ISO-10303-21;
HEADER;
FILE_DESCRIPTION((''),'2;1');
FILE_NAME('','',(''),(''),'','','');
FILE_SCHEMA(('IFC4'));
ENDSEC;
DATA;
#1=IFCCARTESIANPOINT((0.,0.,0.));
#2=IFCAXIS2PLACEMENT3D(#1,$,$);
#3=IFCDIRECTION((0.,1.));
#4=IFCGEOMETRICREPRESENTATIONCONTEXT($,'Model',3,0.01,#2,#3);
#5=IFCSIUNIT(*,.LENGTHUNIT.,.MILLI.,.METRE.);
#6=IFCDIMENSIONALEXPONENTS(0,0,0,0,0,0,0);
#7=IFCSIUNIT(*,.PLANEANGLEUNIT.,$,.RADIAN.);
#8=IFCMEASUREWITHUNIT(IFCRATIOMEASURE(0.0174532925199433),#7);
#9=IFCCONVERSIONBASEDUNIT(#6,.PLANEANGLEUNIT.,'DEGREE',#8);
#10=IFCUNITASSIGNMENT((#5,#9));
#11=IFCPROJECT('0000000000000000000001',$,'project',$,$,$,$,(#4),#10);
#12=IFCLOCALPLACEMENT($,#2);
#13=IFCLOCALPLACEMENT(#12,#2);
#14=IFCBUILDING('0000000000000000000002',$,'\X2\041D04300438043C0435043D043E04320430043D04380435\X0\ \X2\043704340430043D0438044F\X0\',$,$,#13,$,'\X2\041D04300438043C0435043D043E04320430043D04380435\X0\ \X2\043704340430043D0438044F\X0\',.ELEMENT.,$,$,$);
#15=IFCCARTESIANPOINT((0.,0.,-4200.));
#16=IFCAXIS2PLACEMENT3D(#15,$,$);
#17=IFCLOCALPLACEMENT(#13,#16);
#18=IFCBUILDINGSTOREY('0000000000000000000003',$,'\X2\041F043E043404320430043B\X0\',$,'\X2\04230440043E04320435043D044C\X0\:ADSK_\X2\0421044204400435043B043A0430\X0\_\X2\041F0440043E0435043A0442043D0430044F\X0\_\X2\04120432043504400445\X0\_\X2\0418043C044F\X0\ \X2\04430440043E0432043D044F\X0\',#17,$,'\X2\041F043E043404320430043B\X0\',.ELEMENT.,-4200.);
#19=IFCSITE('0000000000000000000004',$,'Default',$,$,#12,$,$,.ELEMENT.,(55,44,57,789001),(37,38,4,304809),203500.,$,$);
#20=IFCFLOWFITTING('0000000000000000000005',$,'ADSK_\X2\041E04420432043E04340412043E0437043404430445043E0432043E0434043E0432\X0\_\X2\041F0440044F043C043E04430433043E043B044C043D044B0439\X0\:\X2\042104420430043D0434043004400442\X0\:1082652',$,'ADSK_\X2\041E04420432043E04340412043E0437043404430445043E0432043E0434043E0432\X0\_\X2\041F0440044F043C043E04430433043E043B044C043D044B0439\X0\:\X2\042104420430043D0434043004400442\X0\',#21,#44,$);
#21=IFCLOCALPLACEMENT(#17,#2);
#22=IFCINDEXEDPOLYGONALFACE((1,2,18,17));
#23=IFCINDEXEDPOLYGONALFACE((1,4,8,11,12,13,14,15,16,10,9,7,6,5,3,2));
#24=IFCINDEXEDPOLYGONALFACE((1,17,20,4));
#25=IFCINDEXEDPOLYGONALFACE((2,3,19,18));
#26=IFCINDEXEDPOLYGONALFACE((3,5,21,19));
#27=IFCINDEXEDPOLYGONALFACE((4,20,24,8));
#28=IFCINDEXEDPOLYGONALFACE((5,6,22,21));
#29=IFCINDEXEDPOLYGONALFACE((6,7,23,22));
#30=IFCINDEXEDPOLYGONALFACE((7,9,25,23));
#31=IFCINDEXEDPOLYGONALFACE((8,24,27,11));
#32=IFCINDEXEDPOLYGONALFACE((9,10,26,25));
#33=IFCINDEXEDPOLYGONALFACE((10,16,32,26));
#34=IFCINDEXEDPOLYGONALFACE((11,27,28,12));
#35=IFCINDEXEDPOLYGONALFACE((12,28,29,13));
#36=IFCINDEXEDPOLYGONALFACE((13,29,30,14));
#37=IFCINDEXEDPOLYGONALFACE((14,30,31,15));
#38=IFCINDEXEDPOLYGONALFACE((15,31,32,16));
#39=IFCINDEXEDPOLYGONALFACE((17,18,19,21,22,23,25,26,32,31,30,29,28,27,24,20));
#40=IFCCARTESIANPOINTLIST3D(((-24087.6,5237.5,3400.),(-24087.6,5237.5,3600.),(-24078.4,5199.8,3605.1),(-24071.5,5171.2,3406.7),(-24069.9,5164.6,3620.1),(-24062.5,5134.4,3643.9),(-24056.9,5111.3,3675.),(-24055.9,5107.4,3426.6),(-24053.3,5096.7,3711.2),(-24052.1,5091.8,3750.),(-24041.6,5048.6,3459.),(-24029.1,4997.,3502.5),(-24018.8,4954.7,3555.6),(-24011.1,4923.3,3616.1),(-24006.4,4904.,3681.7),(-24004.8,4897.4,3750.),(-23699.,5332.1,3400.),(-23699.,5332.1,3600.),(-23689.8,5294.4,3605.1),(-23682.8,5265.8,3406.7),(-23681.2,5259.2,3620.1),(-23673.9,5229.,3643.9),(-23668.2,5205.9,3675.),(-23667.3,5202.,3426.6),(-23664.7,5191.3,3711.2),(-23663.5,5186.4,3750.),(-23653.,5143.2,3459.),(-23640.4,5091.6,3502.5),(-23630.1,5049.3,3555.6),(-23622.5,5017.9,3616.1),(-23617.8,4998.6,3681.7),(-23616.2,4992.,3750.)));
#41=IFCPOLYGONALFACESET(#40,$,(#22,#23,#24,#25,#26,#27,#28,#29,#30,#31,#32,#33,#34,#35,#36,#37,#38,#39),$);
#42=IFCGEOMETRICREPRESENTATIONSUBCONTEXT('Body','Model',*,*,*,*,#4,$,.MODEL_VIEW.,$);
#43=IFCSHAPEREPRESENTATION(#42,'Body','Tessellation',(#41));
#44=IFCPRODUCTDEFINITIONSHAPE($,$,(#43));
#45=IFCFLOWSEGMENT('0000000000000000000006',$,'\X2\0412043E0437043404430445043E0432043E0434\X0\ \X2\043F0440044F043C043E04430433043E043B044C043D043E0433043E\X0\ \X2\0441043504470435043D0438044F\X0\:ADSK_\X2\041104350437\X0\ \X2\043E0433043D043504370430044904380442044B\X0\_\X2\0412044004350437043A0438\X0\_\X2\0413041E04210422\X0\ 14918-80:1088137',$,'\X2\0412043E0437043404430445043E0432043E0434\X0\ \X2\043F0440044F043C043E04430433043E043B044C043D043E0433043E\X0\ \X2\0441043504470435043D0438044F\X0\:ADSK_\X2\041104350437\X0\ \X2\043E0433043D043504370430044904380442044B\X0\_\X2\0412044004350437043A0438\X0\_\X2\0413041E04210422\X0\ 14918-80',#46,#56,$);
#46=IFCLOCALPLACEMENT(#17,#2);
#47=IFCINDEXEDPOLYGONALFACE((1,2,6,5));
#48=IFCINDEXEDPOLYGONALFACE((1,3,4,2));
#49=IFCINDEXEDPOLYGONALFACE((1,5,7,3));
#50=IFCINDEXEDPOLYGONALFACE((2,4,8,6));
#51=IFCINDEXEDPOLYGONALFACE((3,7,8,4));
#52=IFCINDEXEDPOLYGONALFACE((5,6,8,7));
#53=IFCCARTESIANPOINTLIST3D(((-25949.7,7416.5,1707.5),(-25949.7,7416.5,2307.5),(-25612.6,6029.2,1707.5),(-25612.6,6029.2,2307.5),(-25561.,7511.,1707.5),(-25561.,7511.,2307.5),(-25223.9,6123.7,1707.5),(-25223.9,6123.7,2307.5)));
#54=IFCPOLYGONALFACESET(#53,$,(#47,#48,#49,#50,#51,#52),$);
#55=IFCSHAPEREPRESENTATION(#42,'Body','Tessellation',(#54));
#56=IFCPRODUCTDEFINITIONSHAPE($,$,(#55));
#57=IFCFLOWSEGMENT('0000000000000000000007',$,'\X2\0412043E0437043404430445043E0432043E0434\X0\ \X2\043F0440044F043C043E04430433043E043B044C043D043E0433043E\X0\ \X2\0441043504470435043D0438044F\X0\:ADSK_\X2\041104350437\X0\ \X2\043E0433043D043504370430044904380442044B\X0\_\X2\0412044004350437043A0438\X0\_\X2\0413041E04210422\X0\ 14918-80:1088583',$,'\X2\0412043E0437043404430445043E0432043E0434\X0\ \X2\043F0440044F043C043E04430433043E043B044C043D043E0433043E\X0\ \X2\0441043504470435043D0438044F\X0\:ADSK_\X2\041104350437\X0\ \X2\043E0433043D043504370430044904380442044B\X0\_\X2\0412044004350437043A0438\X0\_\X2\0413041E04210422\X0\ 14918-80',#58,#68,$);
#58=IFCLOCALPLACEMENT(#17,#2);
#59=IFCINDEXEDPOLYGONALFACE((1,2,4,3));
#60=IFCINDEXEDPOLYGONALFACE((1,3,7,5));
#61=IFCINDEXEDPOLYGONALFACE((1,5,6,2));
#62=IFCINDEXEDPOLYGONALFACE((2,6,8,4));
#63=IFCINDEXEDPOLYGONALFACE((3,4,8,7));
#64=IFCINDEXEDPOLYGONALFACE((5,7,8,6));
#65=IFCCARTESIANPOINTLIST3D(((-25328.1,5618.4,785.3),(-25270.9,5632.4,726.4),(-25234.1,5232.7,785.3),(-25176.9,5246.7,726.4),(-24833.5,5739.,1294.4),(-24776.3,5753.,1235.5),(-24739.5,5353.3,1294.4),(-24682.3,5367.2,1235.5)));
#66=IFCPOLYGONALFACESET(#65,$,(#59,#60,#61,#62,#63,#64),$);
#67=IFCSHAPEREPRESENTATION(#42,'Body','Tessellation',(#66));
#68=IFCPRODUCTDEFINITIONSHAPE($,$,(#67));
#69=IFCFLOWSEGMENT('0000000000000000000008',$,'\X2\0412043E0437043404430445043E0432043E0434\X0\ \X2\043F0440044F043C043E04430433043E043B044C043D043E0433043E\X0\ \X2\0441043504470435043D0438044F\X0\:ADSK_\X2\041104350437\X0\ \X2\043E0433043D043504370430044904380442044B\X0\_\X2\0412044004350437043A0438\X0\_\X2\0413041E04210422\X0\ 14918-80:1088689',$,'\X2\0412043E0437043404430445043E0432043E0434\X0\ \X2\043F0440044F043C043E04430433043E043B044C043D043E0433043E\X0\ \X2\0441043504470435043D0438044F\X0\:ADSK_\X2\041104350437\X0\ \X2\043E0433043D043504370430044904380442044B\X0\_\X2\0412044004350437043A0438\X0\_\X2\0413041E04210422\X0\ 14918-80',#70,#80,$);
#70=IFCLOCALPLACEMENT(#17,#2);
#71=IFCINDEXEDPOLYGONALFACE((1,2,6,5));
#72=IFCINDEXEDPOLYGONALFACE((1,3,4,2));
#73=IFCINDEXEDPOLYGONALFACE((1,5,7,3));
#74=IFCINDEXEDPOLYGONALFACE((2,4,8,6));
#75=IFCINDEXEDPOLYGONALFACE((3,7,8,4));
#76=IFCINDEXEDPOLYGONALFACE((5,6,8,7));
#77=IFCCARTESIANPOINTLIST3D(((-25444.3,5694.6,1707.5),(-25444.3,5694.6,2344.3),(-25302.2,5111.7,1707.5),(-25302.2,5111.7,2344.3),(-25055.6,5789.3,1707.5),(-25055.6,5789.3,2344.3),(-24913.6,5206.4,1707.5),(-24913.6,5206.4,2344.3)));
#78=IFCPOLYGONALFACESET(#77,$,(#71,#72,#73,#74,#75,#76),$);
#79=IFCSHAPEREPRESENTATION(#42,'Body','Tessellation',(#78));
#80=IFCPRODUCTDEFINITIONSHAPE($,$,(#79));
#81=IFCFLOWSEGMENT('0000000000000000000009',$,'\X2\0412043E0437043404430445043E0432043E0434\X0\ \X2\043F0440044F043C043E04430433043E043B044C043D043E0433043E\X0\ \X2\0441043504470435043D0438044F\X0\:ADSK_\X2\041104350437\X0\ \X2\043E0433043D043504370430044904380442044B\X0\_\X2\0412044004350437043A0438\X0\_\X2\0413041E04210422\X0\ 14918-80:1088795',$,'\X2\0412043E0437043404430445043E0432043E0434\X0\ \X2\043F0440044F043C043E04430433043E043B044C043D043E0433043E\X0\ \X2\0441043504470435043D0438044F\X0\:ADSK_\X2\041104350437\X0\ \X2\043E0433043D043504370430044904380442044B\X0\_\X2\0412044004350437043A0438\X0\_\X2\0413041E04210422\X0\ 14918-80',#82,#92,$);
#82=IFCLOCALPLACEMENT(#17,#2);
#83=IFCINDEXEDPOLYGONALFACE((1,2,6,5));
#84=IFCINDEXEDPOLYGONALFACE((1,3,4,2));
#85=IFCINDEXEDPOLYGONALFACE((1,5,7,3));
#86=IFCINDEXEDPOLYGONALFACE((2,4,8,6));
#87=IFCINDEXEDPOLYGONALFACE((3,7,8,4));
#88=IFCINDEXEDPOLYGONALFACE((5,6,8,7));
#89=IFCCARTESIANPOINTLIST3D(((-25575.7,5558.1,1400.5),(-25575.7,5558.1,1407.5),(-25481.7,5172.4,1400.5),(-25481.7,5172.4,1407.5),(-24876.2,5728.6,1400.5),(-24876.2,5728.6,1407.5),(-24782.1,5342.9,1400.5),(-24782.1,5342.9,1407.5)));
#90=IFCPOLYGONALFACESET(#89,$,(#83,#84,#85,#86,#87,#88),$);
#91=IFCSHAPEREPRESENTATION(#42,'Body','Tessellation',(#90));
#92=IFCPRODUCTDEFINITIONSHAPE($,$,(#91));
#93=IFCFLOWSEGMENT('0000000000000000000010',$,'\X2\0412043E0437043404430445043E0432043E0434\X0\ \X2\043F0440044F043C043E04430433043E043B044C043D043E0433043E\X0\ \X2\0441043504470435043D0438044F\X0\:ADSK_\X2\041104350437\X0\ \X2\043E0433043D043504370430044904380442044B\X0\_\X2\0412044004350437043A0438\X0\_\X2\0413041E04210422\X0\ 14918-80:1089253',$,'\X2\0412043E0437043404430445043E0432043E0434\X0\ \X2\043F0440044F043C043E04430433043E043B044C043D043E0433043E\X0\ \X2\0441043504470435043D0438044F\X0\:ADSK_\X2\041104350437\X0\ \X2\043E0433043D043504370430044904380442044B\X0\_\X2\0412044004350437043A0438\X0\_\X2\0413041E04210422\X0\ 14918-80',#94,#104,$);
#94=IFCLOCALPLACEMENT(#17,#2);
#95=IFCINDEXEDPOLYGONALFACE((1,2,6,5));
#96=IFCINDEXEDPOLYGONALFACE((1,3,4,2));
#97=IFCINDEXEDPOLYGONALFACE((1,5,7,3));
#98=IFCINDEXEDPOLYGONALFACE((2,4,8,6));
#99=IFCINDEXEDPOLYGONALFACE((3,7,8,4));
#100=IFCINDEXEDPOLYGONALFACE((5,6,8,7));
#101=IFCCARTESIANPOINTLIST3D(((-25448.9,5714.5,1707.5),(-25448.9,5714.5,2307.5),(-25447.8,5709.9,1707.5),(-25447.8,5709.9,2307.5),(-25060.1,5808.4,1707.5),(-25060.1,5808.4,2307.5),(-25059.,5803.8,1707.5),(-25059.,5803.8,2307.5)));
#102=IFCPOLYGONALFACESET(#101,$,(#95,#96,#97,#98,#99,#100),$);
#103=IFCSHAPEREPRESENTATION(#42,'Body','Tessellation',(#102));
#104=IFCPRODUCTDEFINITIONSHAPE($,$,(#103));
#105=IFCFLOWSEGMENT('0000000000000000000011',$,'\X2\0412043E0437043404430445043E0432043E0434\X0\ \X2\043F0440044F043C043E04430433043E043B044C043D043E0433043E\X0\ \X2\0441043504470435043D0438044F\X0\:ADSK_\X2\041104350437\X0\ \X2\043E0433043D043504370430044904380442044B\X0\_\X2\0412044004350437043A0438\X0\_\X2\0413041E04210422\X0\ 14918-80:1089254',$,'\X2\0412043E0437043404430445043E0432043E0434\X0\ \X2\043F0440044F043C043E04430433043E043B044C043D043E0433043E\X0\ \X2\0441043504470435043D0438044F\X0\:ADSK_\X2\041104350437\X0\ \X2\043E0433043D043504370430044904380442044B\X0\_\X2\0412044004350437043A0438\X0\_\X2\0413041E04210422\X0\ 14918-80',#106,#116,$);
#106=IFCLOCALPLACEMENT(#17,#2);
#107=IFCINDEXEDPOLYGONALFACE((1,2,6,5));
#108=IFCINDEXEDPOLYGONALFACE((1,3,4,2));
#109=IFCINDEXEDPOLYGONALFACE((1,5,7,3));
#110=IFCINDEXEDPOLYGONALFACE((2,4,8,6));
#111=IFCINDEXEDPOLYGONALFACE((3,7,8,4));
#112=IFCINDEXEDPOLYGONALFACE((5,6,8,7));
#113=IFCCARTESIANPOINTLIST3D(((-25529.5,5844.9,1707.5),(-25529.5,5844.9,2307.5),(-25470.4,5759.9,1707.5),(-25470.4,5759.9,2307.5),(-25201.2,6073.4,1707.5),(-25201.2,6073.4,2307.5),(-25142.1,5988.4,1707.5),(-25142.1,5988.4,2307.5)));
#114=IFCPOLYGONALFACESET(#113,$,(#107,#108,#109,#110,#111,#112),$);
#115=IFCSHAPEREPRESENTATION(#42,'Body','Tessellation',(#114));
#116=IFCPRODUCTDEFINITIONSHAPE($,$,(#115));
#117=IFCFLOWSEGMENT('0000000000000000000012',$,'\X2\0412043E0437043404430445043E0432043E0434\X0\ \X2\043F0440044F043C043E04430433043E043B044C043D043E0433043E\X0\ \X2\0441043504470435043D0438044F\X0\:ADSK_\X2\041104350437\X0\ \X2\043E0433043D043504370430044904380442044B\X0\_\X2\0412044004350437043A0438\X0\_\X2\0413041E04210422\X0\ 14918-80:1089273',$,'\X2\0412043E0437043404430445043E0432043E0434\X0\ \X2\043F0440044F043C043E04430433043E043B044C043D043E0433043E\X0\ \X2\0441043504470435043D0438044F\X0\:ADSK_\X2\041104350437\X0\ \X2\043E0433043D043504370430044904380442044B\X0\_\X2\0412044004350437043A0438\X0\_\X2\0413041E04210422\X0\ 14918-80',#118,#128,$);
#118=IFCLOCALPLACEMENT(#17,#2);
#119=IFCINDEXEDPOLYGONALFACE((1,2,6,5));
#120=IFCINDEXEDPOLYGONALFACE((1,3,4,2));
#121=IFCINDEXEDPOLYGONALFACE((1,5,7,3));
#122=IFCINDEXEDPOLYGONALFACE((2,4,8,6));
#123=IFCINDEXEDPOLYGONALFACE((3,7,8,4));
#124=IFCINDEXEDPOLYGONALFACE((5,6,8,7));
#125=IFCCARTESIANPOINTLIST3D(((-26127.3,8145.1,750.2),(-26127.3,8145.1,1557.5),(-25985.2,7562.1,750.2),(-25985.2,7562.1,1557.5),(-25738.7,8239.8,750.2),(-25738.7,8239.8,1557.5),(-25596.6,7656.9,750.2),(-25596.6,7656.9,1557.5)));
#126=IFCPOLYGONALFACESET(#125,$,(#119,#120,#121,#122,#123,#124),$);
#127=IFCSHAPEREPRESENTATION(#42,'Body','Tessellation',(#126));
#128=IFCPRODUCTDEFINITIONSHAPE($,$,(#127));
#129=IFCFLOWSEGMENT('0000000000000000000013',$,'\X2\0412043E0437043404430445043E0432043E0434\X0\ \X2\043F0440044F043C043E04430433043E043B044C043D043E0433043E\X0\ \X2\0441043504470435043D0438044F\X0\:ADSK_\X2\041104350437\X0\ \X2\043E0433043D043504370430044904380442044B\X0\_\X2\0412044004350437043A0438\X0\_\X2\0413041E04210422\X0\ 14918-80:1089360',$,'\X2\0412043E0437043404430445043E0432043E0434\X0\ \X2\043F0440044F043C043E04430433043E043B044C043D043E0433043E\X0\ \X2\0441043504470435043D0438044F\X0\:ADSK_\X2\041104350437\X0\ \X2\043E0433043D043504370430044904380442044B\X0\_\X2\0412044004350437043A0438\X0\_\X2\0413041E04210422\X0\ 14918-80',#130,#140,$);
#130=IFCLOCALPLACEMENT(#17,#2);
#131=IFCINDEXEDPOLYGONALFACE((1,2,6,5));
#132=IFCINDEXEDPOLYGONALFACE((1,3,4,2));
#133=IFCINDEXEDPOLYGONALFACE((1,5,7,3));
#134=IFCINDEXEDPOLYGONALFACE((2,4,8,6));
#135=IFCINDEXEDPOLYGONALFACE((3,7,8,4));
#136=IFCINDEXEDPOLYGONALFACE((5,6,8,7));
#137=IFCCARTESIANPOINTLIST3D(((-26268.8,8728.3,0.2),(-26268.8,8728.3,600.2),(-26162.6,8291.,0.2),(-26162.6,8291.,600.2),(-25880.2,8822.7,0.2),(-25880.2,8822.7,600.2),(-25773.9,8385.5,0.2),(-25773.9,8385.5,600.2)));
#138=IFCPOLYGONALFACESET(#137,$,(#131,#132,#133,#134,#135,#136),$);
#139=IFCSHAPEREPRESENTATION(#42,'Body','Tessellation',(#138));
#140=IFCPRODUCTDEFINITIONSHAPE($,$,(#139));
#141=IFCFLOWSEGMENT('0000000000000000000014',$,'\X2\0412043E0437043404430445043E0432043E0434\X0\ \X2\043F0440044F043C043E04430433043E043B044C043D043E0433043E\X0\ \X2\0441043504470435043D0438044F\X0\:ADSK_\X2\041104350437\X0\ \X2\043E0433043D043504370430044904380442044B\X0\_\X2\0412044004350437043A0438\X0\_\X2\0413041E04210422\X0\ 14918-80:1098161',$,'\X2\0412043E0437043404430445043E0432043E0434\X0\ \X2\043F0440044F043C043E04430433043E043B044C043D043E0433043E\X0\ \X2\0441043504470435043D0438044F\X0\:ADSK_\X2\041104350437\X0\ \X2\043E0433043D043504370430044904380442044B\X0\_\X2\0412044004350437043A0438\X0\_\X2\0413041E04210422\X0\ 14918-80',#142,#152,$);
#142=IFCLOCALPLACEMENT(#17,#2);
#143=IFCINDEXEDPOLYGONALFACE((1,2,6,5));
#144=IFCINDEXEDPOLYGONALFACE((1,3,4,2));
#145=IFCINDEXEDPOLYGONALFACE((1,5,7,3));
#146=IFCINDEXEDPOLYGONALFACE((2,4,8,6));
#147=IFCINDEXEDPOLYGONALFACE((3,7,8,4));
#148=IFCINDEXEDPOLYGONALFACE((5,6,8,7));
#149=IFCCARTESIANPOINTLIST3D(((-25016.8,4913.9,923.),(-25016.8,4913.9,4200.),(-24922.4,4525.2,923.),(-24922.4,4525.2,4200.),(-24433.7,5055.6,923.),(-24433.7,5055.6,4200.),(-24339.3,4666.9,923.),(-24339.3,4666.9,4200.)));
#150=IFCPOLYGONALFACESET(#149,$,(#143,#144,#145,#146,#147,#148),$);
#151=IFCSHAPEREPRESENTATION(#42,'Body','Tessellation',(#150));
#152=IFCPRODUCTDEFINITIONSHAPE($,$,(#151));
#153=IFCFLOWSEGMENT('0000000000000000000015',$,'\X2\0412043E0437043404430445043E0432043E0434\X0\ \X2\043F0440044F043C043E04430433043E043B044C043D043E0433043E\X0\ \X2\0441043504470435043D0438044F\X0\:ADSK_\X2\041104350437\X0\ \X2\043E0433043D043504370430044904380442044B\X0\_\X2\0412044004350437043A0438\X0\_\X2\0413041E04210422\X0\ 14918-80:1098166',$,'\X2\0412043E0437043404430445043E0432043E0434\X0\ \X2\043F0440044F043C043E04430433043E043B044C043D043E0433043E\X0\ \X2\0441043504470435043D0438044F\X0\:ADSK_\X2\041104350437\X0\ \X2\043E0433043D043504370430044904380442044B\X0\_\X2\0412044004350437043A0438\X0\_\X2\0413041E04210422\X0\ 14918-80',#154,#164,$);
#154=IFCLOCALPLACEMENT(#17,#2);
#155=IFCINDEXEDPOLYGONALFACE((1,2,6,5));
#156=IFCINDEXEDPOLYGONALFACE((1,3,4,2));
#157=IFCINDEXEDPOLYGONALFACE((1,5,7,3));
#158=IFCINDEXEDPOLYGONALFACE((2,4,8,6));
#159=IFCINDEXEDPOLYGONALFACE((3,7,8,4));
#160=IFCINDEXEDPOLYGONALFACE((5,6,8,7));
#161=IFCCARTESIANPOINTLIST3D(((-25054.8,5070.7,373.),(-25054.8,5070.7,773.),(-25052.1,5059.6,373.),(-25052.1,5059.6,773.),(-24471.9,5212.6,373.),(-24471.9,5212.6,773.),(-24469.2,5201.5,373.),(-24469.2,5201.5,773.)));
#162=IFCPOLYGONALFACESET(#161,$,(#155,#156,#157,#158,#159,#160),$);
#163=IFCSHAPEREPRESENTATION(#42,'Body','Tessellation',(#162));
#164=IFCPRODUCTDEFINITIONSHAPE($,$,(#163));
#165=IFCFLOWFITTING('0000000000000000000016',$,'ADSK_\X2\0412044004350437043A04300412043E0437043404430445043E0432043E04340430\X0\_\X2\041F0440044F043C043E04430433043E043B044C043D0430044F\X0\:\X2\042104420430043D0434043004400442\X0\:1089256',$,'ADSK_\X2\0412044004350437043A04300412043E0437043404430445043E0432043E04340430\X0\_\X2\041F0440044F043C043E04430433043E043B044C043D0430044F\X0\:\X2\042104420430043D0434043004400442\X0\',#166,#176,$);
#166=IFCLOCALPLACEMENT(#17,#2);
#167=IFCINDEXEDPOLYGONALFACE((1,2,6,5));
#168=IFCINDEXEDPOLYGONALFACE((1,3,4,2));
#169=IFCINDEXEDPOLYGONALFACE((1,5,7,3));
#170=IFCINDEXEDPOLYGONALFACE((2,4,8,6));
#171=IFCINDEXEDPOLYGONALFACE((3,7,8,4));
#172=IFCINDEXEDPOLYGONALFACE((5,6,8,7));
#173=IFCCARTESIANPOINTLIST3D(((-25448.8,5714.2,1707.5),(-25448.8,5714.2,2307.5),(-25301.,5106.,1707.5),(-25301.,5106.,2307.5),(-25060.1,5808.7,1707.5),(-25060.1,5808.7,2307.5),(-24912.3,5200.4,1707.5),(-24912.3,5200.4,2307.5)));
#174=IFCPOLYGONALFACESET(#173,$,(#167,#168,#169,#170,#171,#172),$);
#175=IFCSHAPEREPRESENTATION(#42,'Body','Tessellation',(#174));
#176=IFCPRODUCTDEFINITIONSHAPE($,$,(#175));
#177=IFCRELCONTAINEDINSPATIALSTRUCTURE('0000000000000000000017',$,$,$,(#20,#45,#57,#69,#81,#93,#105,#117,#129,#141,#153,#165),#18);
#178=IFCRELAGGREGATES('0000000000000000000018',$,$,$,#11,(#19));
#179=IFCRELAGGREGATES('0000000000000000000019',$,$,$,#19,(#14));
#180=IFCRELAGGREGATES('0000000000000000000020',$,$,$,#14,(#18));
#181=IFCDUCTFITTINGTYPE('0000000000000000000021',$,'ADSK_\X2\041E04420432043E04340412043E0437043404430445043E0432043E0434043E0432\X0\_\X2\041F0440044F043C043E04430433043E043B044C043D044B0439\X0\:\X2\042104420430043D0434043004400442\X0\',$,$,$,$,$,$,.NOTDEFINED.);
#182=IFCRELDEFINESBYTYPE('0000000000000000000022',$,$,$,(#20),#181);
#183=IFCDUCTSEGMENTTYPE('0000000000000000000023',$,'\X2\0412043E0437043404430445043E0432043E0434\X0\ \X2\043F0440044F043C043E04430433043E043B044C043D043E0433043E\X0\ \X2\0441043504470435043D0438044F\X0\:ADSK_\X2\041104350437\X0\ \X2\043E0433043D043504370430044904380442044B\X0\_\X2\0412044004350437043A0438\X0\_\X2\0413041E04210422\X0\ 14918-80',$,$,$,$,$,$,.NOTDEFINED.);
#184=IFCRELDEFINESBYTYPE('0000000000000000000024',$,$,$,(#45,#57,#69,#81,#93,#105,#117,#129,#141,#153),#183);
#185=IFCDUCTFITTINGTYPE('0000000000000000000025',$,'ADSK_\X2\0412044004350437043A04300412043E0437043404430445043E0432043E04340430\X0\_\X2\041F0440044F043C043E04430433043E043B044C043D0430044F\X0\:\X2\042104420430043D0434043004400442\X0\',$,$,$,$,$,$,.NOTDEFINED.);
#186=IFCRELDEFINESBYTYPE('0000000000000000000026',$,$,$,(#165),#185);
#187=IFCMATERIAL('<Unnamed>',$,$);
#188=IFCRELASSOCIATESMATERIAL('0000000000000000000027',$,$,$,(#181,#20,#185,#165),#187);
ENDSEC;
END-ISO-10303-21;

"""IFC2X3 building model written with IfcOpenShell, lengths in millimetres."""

from ifc_helpers import new_model, entity, si_unit, converted_unit, direction, frame, frame_2d, origin, origin_2d_with_axis, place, context, subcontext, project, spatial, polyline, circle_curve, parameter, trimmed, segment, composite_curve, rectangle, outline, extrude, source, transform, mapped, material, type_object, type_shapes, element, save


model = new_model("IFC2X3")

# Units and contexts
model_context = context("Model", 3, precision=0.01, world=origin(), true_north=direction((0.0, 1.0)))
body_context = subcontext(model_context, "Body", "Model", "MODEL_VIEW")
ifc_project = project(units=[si_unit("LENGTHUNIT", "METRE", prefix="MILLI"), converted_unit("PLANEANGLEUNIT", "DEGREE", entity("IfcRatioMeasure", 0.0174532925199433), si_unit("PLANEANGLEUNIT", "RADIAN"), dimensions=[0, 0, 0, 0, 0, 0, 0])], contexts=[model_context])

# Site, building, storey
site_placement = place(None, frame((0.0, 0.0, 0.0)))
site = spatial("IfcSite", under=ifc_project, at=site_placement, Name="Default", CompositionType="ELEMENT", RefLatitude=(55, 44, 57, 789001), RefLongitude=(37, 38, 4, 304809), RefElevation=203500.0)
building_placement = place(site_placement, origin())
building = spatial("IfcBuilding", under=site, at=building_placement, Name="Наименование здания", LongName="Наименование здания", CompositionType="ELEMENT")
storey_placement = place(building_placement, frame((0.0, 0.0, -4200.0)))
storey = spatial("IfcBuildingStorey", under=building, at=storey_placement, Name="Подвал", ObjectType="Уровень:ADSK_Стрелка_Проектная_Вверх_Имя уровня", LongName="Подвал", CompositionType="ELEMENT", Elevation=-4200.0)

# Shared definitions
ifc_material_1 = material(Name="<Unnamed>")

# Flow fitting
duct_fitting_type_1 = type_object("IfcDuctFittingType", Name="ADSK_ОтводВоздуховодов_Прямоугольный:Стандарт", PredefinedType="NOTDEFINED", material=ifc_material_1)
shared_shape_1 = source(origin(), body_context, "Body", "SweptSolid", [
    extrude(outline(composite_curve([segment(polyline([(-225.0, -125.0), (-25.0, -125.0)]), True, "CONTINUOUS"), segment(trimmed(circle_curve(frame_2d((125.0, -125.0), x_axis=(0.0, 1.0)), 150.0), [parameter(0.0)], [parameter(90.0)], True, "PARAMETER"), False, "CONTINUOUS"), segment(polyline([(125.0, 25.0), (125.0, 225.0)]), True, "CONTINUOUS"), segment(trimmed(circle_curve(frame_2d((125.0, -125.0), x_axis=(0.0, 1.0)), 350.0), [parameter(0.0)], [parameter(90.0)], True, "PARAMETER"), True, "CONTINUOUS")], self_intersect=False)), frame((-125.0, 125.0, -200.0), z_axis=(0.0, 0.0, 1.0), x_axis=(-1.0, 0.0, 0.0)), (0.0, 0.0, 1.0), 400.0),
])
type_shapes(duct_fitting_type_1, [shared_shape_1])
flow_fitting_1_placement = place(storey_placement, frame((-23834.1, 5041.9, 3500.0), z_axis=(-0.971627, -0.236517, 0.0), x_axis=(0.236517, -0.971627, 0.0)))
element("IfcFlowFitting", 1, at=flow_fitting_1_placement, inside=storey, type_object=duct_fitting_type_1, material=ifc_material_1, Name="ADSK_ОтводВоздуховодов_Прямоугольный:Стандарт:1082652", ObjectType="ADSK_ОтводВоздуховодов_Прямоугольный:Стандарт", context=body_context, shape_type="MappedRepresentation", body=[
    mapped(shared_shape_1, transform((0.0, 0.0, 0.0), scale=1.0)),
])

# Flow segments
duct_segment_type_1 = type_object("IfcDuctSegmentType", Name="Воздуховод прямоугольного сечения:ADSK_Без огнезащиты_Врезки_ГОСТ 14918-80", PredefinedType="NOTDEFINED")
flow_segment_1_placement = place(storey_placement, frame((-25949.7, 6029.2, 1707.5)))
element("IfcFlowSegment", 2, at=flow_segment_1_placement, inside=storey, type_object=duct_segment_type_1, Name="Воздуховод прямоугольного сечения:ADSK_Без огнезащиты_Врезки_ГОСТ 14918-80:1088137", ObjectType="Воздуховод прямоугольного сечения:ADSK_Без огнезащиты_Врезки_ГОСТ 14918-80", context=body_context, shape_type="SweptSolid", body=[
    extrude(rectangle(XDim=1427.7, YDim=400.0, at=frame_2d((0.0, 0.0), x_axis=(1.0, 0.0))), frame((362.9, 740.9, 0.0), z_axis=(0.0, 0.0, 1.0), x_axis=(-0.23616, 0.971714, 0.0)), (0.0, 0.0, 1.0), 600.0),
])
flow_segment_2_placement = place(storey_placement, frame((-25328.1, 5232.7, 726.4)))
element("IfcFlowSegment", 3, at=flow_segment_2_placement, inside=storey, type_object=duct_segment_type_1, Name="Воздуховод прямоугольного сечения:ADSK_Без огнезащиты_Врезки_ГОСТ 14918-80:1088583", ObjectType="Воздуховод прямоугольного сечения:ADSK_Без огнезащиты_Врезки_ГОСТ 14918-80", context=body_context, shape_type="SweptSolid", body=[
    extrude(rectangle(XDim=83.3, YDim=397.0, at=frame_2d((0.0, 0.0), x_axis=(1.0, 0.0))), frame((75.6, 199.8, 29.4), z_axis=(0.686992, 0.167458, 0.707107), x_axis=(-0.686992, -0.167458, 0.707107)), (0.0, 0.0, 1.0), 720.0),
])
flow_segment_3_placement = place(storey_placement, frame((-25444.3, 5111.7, 1707.5)))
element("IfcFlowSegment", 4, at=flow_segment_3_placement, inside=storey, type_object=duct_segment_type_1, Name="Воздуховод прямоугольного сечения:ADSK_Без огнезащиты_Врезки_ГОСТ 14918-80:1088689", ObjectType="Воздуховод прямоугольного сечения:ADSK_Без огнезащиты_Врезки_ГОСТ 14918-80", context=body_context, shape_type="SweptSolid", body=[
    extrude(rectangle(XDim=600.0, YDim=400.0, at=origin_2d_with_axis()), frame((265.4, 338.8, 0.0), z_axis=(0.0, 0.0, 1.0), x_axis=(0.236821, -0.971553, 0.0)), (0.0, 0.0, 1.0), 636.8),
])
flow_segment_4_placement = place(storey_placement, frame((-25575.7, 5172.4, 1400.5)))
element("IfcFlowSegment", 5, at=flow_segment_4_placement, inside=storey, type_object=duct_segment_type_1, Name="Воздуховод прямоугольного сечения:ADSK_Без огнезащиты_Врезки_ГОСТ 14918-80:1088795", ObjectType="Воздуховод прямоугольного сечения:ADSK_Без огнезащиты_Врезки_ГОСТ 14918-80", context=body_context, shape_type="SweptSolid", body=[
    extrude(rectangle(XDim=397.0, YDim=720.0, at=frame_2d((0.0, 0.0), x_axis=(1.0, 0.0))), frame((396.8, 278.1, 0.0), z_axis=(0.0, 0.0, 1.0), x_axis=(-0.236821, 0.971553, 0.0)), (0.0, 0.0, 1.0), 7.0),
])
flow_segment_5_placement = place(storey_placement, frame((-25448.9, 5709.9, 1707.5)))
element("IfcFlowSegment", 6, at=flow_segment_5_placement, inside=storey, type_object=duct_segment_type_1, Name="Воздуховод прямоугольного сечения:ADSK_Без огнезащиты_Врезки_ГОСТ 14918-80:1089253", ObjectType="Воздуховод прямоугольного сечения:ADSK_Без огнезащиты_Врезки_ГОСТ 14918-80", context=body_context, shape_type="SweptSolid", body=[
    extrude(rectangle(XDim=4.8, YDim=400.0, at=origin_2d_with_axis()), frame((195.0, 49.3, 0.0), z_axis=(0.0, 0.0, 1.0), x_axis=(0.234768, -0.972051, 0.0)), (0.0, 0.0, 1.0), 600.0),
])
flow_segment_6_placement = place(storey_placement, frame((-25529.5, 5759.9, 1707.5)))
element("IfcFlowSegment", 7, at=flow_segment_6_placement, inside=storey, type_object=duct_segment_type_1, Name="Воздуховод прямоугольного сечения:ADSK_Без огнезащиты_Врезки_ГОСТ 14918-80:1089254", ObjectType="Воздуховод прямоугольного сечения:ADSK_Без огнезащиты_Врезки_ГОСТ 14918-80", context=body_context, shape_type="SweptSolid", body=[
    extrude(rectangle(XDim=103.6, YDim=400.0, at=origin_2d_with_axis()), frame((193.7, 156.8, 0.0), z_axis=(0.0, 0.0, 1.0), x_axis=(-0.571319, 0.820728, 0.0)), (0.0, 0.0, 1.0), 600.0),
])
flow_segment_7_placement = place(storey_placement, frame((-26127.3, 7562.1, 750.2)))
element("IfcFlowSegment", 8, at=flow_segment_7_placement, inside=storey, type_object=duct_segment_type_1, Name="Воздуховод прямоугольного сечения:ADSK_Без огнезащиты_Врезки_ГОСТ 14918-80:1089273", ObjectType="Воздуховод прямоугольного сечения:ADSK_Без огнезащиты_Врезки_ГОСТ 14918-80", context=body_context, shape_type="SweptSolid", body=[
    extrude(rectangle(XDim=400.0, YDim=600.0, at=frame_2d((0.0, 0.0), x_axis=(1.0, 0.0))), frame((265.4, 338.8, 0.0), z_axis=(0.0, 0.0, 1.0), x_axis=(-0.971553, -0.236821, 0.0)), (0.0, 0.0, 1.0), 807.3),
])
flow_segment_8_placement = place(storey_placement, frame((-26268.8, 8291.0, 0.2)))
element("IfcFlowSegment", 9, at=flow_segment_8_placement, inside=storey, type_object=duct_segment_type_1, Name="Воздуховод прямоугольного сечения:ADSK_Без огнезащиты_Врезки_ГОСТ 14918-80:1089360", ObjectType="Воздуховод прямоугольного сечения:ADSK_Без огнезащиты_Врезки_ГОСТ 14918-80", context=body_context, shape_type="SweptSolid", body=[
    extrude(rectangle(XDim=450.0, YDim=400.0, at=origin_2d_with_axis()), frame((247.5, 265.9, 0.0), z_axis=(0.0, 0.0, 1.0), x_axis=(-0.23616, 0.971714, 0.0)), (0.0, 0.0, 1.0), 600.0),
])
flow_segment_9_placement = place(storey_placement, frame((-25016.8, 4525.2, 923.0)))
element("IfcFlowSegment", 10, at=flow_segment_9_placement, inside=storey, type_object=duct_segment_type_1, Name="Воздуховод прямоугольного сечения:ADSK_Без огнезащиты_Врезки_ГОСТ 14918-80:1098161", ObjectType="Воздуховод прямоугольного сечения:ADSK_Без огнезащиты_Врезки_ГОСТ 14918-80", context=body_context, shape_type="SweptSolid", body=[
    extrude(rectangle(XDim=600.0, YDim=400.0, at=frame_2d((0.0, 0.0), x_axis=(1.0, 0.0))), frame((338.7, 265.2, 0.0), z_axis=(0.0, 0.0, 1.0), x_axis=(0.971743, 0.23604, 0.0)), (0.0, 0.0, 1.0), 3277.0),
])
flow_segment_10_placement = place(storey_placement, frame((-25054.8, 5059.6, 373.0)))
element("IfcFlowSegment", 11, at=flow_segment_10_placement, inside=storey, type_object=duct_segment_type_1, Name="Воздуховод прямоугольного сечения:ADSK_Без огнезащиты_Врезки_ГОСТ 14918-80:1098166", ObjectType="Воздуховод прямоугольного сечения:ADSK_Без огнезащиты_Врезки_ГОСТ 14918-80", context=body_context, shape_type="SweptSolid", body=[
    extrude(rectangle(XDim=11.4, YDim=600.0, at=origin_2d_with_axis()), frame((292.8, 76.5, 0.0), z_axis=(0.0, 0.0, 1.0), x_axis=(0.236532, -0.971624, 0.0)), (0.0, 0.0, 1.0), 400.0),
])

# Flow fitting
duct_fitting_type_2 = type_object("IfcDuctFittingType", Name="ADSK_ВрезкаВоздуховода_Прямоугольная:Стандарт", PredefinedType="NOTDEFINED", material=ifc_material_1)
shared_shape_2 = source(origin(), body_context, "Body", "SweptSolid", [
    extrude(rectangle(XDim=626.0, YDim=600.0, at=frame_2d((0.0, 0.0), x_axis=(1.0, 0.0))), frame((-293.0, 0.0, -200.0)), (0.0, 0.0, 1.0), 400.0),
])
type_shapes(duct_fitting_type_2, [shared_shape_2])
flow_fitting_2_placement = place(storey_placement, frame((-25249.8, 5742.0, 2007.5), z_axis=(0.971714, 0.23616, 0.0), x_axis=(-0.23616, 0.971714, 0.0)))
element("IfcFlowFitting", 12, at=flow_fitting_2_placement, inside=storey, type_object=duct_fitting_type_2, material=ifc_material_1, Name="ADSK_ВрезкаВоздуховода_Прямоугольная:Стандарт:1089256", ObjectType="ADSK_ВрезкаВоздуховода_Прямоугольная:Стандарт", context=body_context, shape_type="MappedRepresentation", body=[
    mapped(shared_shape_2, transform((0.0, 0.0, 0.0), scale=1.0)),
])

save(model, "model.ifc")
